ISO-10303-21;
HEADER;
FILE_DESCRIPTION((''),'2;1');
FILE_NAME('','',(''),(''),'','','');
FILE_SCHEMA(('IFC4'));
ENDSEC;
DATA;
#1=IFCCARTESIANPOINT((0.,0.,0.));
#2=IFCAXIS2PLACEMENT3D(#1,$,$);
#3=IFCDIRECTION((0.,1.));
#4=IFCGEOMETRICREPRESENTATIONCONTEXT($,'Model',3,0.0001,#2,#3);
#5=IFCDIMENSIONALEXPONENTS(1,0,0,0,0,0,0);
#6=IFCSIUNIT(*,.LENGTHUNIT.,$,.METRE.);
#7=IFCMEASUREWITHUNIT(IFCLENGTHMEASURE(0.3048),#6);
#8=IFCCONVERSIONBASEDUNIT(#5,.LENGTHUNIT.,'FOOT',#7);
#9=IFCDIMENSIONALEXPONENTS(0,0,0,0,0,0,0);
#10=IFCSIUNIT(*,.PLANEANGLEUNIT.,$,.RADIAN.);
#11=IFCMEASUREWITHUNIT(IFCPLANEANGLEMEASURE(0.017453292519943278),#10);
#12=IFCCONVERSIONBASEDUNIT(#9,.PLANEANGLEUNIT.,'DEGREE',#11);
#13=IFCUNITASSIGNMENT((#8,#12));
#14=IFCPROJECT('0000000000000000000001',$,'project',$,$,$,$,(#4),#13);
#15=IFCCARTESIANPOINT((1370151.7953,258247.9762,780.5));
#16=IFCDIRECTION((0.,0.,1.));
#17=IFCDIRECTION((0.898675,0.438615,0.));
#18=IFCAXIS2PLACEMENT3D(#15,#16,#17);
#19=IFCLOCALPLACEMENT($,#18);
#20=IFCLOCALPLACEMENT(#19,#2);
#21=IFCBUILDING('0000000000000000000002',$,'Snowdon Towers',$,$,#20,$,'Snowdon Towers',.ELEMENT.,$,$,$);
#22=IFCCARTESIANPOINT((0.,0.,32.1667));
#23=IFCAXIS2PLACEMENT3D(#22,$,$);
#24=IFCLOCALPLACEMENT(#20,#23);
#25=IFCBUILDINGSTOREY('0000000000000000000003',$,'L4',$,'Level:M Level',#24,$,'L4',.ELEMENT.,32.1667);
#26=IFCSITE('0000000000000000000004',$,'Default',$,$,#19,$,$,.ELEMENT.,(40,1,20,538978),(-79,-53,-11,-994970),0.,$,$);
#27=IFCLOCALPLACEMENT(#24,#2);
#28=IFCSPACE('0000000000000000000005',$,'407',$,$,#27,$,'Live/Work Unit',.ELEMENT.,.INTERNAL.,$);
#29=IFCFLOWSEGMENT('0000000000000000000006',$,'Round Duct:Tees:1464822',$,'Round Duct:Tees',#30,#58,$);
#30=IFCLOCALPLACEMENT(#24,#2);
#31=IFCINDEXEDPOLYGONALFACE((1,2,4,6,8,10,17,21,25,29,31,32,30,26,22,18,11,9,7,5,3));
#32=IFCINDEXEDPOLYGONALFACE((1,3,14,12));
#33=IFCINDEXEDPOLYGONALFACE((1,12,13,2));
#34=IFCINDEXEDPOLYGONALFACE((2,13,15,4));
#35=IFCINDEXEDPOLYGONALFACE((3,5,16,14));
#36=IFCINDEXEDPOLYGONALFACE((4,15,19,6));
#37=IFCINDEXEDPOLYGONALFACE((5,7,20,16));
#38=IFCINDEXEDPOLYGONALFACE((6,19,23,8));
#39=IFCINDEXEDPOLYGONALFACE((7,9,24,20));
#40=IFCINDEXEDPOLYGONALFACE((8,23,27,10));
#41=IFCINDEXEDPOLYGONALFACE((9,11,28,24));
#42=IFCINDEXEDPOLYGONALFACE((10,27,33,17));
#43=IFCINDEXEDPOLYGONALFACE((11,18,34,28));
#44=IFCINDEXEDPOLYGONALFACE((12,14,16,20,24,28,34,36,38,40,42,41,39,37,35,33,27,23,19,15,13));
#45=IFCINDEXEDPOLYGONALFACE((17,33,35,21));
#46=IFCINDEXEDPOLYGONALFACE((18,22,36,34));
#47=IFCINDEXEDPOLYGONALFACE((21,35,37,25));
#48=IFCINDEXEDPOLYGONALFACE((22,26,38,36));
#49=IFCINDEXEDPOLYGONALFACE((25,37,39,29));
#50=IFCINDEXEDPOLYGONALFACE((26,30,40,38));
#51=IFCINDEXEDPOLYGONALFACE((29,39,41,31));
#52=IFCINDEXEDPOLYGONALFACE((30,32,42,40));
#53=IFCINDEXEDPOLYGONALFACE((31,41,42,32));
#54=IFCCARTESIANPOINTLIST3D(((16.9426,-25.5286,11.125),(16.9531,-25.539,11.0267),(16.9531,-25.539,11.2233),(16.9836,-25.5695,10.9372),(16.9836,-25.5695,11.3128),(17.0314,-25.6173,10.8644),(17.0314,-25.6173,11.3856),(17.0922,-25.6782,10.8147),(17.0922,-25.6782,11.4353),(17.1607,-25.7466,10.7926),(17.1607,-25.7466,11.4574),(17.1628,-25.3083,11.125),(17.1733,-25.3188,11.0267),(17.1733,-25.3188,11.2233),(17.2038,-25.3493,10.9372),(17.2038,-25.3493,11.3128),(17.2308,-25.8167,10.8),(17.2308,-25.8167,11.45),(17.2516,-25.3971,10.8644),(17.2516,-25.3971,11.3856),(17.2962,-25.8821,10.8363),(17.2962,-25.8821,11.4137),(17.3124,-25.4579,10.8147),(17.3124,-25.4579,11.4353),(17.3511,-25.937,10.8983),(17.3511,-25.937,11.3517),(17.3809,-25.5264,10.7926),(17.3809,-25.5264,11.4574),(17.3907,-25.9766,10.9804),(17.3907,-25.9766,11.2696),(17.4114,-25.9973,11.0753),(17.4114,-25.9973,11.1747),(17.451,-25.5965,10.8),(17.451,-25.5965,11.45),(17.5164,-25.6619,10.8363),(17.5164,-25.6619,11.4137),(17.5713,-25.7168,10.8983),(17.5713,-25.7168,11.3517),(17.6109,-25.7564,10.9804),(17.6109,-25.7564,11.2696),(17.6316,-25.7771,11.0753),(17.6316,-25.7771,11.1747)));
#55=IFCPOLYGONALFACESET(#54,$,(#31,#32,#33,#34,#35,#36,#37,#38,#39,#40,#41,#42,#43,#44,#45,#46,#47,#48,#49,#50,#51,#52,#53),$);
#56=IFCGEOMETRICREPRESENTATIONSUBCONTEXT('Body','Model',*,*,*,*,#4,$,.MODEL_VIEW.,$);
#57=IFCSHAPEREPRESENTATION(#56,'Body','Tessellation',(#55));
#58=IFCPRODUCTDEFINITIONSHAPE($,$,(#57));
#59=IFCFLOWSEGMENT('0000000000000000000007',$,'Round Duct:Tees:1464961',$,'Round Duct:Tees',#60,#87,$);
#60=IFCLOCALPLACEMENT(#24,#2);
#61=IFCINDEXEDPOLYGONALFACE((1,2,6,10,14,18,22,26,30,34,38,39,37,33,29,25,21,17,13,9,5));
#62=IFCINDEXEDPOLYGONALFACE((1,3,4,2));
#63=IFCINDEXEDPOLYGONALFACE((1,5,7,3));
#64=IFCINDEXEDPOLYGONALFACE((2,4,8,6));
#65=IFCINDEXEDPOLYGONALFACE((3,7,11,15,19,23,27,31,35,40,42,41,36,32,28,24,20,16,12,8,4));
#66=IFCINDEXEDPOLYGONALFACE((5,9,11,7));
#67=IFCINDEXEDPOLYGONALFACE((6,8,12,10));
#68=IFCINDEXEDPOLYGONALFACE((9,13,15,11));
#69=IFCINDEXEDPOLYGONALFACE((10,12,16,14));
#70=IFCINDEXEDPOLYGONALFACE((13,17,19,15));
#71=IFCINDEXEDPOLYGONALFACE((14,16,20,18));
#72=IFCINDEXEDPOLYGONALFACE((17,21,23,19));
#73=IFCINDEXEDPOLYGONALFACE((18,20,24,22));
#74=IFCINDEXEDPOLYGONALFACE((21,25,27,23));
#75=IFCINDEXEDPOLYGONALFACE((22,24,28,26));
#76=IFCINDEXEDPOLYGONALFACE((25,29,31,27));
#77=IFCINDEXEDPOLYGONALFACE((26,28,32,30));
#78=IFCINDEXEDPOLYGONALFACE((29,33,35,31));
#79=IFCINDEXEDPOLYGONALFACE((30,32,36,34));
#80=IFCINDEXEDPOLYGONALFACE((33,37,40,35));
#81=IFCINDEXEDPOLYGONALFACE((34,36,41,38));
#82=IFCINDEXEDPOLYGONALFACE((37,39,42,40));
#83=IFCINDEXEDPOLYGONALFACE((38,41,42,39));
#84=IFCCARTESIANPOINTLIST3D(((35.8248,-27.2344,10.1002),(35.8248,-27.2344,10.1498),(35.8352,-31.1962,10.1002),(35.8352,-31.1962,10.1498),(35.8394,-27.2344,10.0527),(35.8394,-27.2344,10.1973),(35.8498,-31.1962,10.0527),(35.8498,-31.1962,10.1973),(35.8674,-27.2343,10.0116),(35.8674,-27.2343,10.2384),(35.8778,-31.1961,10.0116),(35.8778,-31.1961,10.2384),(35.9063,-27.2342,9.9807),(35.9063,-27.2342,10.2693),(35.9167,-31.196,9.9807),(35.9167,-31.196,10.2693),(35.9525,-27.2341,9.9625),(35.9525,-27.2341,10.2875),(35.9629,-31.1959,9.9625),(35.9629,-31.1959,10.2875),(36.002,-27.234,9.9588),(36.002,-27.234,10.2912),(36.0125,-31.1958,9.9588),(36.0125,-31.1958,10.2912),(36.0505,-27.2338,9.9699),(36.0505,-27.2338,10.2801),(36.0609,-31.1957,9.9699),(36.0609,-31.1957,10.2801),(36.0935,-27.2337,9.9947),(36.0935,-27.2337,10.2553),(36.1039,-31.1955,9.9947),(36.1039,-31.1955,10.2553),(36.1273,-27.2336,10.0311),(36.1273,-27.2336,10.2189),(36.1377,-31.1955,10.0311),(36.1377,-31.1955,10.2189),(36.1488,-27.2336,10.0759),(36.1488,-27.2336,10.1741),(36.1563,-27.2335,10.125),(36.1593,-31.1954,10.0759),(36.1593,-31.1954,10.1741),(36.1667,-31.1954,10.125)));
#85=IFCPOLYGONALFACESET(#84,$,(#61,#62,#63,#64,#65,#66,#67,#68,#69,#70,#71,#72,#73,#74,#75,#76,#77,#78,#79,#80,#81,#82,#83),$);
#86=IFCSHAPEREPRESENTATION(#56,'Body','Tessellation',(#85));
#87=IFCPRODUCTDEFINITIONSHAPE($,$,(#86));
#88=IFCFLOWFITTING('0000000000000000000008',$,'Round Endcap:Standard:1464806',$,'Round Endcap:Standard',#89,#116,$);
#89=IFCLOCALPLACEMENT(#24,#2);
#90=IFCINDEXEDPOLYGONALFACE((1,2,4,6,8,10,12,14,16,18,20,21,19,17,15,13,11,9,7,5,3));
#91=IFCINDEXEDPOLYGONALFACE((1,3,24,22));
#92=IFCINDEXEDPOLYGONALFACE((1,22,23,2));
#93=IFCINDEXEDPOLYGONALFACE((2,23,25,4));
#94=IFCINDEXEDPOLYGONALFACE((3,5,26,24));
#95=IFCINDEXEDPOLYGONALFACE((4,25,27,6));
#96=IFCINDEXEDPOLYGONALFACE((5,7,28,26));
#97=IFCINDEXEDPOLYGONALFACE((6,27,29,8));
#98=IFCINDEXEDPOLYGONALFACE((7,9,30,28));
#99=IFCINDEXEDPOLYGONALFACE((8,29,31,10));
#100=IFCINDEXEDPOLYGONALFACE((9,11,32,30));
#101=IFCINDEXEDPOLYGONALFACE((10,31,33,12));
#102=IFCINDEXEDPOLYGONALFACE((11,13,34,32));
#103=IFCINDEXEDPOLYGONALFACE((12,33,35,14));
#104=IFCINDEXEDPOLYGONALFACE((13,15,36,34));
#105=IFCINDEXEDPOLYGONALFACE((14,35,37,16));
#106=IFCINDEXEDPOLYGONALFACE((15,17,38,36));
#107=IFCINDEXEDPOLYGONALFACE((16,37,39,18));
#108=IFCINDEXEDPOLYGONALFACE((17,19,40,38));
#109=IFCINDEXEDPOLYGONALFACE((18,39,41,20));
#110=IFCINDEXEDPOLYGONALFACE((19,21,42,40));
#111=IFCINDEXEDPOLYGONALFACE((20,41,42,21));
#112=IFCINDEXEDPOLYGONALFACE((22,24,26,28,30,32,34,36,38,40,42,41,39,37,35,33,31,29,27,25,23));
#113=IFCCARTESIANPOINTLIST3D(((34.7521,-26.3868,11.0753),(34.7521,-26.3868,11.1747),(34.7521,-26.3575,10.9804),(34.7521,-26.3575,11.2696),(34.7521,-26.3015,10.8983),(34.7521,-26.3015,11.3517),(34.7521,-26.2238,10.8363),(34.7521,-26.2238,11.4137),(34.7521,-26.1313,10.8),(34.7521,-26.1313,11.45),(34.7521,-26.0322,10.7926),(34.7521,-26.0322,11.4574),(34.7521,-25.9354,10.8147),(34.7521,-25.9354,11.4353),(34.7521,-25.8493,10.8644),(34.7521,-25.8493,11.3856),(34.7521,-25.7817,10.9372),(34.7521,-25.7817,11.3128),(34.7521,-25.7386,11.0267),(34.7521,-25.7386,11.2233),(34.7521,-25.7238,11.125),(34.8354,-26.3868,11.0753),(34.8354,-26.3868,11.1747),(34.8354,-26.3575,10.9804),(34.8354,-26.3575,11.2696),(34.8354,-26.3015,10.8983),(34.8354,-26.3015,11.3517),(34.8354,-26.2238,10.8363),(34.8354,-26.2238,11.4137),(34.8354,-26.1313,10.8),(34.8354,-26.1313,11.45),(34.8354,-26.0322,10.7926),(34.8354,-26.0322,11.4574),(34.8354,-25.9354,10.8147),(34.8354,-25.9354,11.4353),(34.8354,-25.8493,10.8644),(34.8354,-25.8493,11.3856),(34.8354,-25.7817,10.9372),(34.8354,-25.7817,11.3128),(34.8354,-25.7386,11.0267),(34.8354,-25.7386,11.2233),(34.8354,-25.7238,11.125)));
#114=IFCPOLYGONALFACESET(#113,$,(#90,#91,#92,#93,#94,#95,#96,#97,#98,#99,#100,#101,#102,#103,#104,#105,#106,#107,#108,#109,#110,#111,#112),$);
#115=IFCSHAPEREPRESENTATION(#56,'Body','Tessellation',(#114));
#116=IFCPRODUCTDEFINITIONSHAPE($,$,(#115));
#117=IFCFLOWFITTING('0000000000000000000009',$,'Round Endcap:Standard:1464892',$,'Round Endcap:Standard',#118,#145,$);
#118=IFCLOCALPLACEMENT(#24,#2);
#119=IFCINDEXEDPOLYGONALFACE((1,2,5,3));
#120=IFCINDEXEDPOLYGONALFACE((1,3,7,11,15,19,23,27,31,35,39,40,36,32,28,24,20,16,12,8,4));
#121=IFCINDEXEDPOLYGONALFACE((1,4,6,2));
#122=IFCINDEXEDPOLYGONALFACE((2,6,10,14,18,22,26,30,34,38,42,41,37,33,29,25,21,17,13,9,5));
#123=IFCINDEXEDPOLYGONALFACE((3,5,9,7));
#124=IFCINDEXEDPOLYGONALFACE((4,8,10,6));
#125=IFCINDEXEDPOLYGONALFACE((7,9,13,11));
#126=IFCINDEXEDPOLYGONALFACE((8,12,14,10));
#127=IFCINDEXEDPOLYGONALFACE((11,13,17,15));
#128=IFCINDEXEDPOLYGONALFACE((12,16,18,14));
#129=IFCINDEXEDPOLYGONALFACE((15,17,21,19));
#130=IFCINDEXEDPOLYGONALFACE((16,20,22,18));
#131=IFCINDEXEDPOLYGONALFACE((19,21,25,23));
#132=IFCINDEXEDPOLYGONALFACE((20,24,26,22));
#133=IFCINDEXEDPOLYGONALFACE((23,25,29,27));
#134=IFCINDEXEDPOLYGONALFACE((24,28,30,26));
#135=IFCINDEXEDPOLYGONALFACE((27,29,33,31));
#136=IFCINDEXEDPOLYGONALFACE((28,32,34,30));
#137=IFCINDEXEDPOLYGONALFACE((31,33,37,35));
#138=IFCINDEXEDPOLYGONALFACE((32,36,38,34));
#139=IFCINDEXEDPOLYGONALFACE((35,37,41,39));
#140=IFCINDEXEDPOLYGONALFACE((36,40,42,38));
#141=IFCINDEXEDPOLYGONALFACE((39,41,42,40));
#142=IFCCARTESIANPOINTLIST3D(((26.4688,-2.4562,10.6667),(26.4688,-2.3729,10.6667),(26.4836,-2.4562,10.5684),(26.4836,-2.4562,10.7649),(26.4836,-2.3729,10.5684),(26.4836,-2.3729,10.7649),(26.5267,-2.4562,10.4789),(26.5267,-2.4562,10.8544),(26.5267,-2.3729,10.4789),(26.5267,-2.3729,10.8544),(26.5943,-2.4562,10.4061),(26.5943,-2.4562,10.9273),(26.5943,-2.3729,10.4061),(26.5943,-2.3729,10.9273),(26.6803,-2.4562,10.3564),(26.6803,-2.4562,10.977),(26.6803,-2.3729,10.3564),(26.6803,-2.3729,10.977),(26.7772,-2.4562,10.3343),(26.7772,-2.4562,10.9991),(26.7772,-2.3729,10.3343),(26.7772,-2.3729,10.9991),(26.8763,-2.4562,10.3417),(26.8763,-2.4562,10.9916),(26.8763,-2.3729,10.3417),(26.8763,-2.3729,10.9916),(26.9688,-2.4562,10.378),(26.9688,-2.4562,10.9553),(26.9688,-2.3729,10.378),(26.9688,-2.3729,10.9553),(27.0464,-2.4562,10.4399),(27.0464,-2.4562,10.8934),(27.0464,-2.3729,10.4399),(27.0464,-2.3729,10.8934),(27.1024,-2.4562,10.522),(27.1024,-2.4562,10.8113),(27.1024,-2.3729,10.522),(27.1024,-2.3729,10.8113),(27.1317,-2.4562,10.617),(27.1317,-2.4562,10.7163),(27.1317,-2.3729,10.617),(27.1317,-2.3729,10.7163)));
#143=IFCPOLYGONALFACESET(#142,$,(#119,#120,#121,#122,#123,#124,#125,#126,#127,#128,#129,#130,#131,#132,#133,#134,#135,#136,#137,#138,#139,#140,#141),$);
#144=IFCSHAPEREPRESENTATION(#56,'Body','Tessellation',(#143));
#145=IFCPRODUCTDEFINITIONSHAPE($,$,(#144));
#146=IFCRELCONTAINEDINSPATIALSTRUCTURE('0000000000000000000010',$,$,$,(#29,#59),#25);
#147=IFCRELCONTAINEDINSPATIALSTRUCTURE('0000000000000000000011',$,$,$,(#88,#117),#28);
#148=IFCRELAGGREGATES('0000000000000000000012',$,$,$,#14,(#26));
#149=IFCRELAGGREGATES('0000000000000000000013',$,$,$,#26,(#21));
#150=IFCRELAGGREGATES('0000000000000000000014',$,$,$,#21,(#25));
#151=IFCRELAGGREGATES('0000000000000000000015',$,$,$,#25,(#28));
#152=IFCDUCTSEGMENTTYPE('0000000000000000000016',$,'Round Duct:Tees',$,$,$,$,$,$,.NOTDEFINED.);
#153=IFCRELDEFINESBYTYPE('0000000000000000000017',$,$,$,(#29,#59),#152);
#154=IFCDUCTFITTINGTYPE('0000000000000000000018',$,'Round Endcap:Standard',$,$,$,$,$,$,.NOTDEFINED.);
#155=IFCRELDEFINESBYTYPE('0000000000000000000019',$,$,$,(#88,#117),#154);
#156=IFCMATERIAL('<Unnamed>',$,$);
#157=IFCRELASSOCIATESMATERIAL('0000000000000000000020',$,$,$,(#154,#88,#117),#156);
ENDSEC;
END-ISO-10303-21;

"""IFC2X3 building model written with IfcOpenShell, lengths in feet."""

from ifc_helpers import new_model, entity, si_unit, converted_unit, direction, frame, frame_2d, origin, origin_2d_with_axis, place, context, subcontext, project, spatial, circle, extrude, source, transform, mapped, material, type_object, type_shapes, element, save


model = new_model("IFC2X3")

# Units and contexts
model_context = context("Model", 3, precision=0.0001, world=origin(), true_north=direction((0.0, 1.0)))
body_context = subcontext(model_context, "Body", "Model", "MODEL_VIEW")
ifc_project = project(units=[converted_unit("LENGTHUNIT", "FOOT", entity("IfcLengthMeasure", 0.3048), si_unit("LENGTHUNIT", "METRE"), dimensions=[1, 0, 0, 0, 0, 0, 0]), converted_unit("PLANEANGLEUNIT", "DEGREE", entity("IfcPlaneAngleMeasure", 0.017453292519943278), si_unit("PLANEANGLEUNIT", "RADIAN"), dimensions=[0, 0, 0, 0, 0, 0, 0])], contexts=[model_context])

# Site, building, storey
site_placement = place(None, frame((1370151.7953, 258247.9762, 780.5), z_axis=(0.0, 0.0, 1.0), x_axis=(0.898675, 0.438615, 0.0)))
site = spatial("IfcSite", under=ifc_project, at=site_placement, Name="Default", CompositionType="ELEMENT", RefLatitude=(40, 1, 20, 538978), RefLongitude=(-79, -53, -11, -994970), RefElevation=0.0)
building_placement = place(site_placement, origin())
building = spatial("IfcBuilding", under=site, at=building_placement, Name="Snowdon Towers", LongName="Snowdon Towers", CompositionType="ELEMENT")
storey_placement = place(building_placement, frame((0.0, 0.0, 32.1667)))
storey = spatial("IfcBuildingStorey", under=building, at=storey_placement, Name="L4", ObjectType="Level:M Level", LongName="L4", CompositionType="ELEMENT", Elevation=32.1667)

# Flow segments
duct_segment_type = type_object("IfcDuctSegmentType", Name="Round Duct:Tees", PredefinedType="NOTDEFINED")
flow_segment_1_placement = place(storey_placement, frame((16.9374, -26.0052, 10.7864)))
element("IfcFlowSegment", 1, at=flow_segment_1_placement, inside=storey, type_object=duct_segment_type, Name="Round Duct:Tees:1464822", ObjectType="Round Duct:Tees", context=body_context, shape_type="SweptSolid", body=[
    extrude(circle(Radius=0.3333, at=origin_2d_with_axis()), frame((0.2409, 0.2409, 0.3386), z_axis=(0.707107, 0.707107, 0.0), x_axis=(-0.707107, 0.707107, 0.0)), (0.0, 0.0, 1.0), 0.3114),
])
flow_segment_2_placement = place(storey_placement, frame((35.8177, -31.1963, 9.9531)))
element("IfcFlowSegment", 2, at=flow_segment_2_placement, inside=storey, type_object=duct_segment_type, Name="Round Duct:Tees:1464961", ObjectType="Round Duct:Tees", context=body_context, shape_type="SweptSolid", body=[
    extrude(circle(Radius=0.1667, at=origin_2d_with_axis()), frame((0.1823, 0.0004, 0.1719), z_axis=(-0.002628, 0.999997, 0.0), x_axis=(0.999997, 0.002628, 0.0)), (0.0, 0.0, 1.0), 3.9618),
])

# Shared definitions
space_placement = place(storey_placement, origin())
space = spatial("IfcSpace", under=storey, at=space_placement, Name="407", LongName="Live/Work Unit", CompositionType="ELEMENT", InteriorOrExteriorSpace="INTERNAL")

# Flow fittings
ifc_material = material(Name="<Unnamed>")
duct_fitting_type = type_object("IfcDuctFittingType", Name="Round Endcap:Standard", PredefinedType="NOTDEFINED", material=ifc_material)
shared_shape_1 = source(origin(), body_context, "Body", "SweptSolid", [
    extrude(circle(Radius=0.3333, at=frame_2d((0.0, 0.0), x_axis=(1.0, 0.0))), frame((0.0, 0.0, 0.0), z_axis=(1.0, 0.0, 0.0), x_axis=(0.0, 1.0, 0.0)), (0.0, 0.0, 1.0), 0.0833),
])
type_shapes(duct_fitting_type, [shared_shape_1])
flow_fitting_1_placement = place(space_placement, frame((34.7521, -26.0572, 11.125)))
element("IfcFlowFitting", 3, at=flow_fitting_1_placement, inside=space, type_object=duct_fitting_type, material=ifc_material, Name="Round Endcap:Standard:1464806", ObjectType="Round Endcap:Standard", context=body_context, shape_type="MappedRepresentation", body=[
    mapped(shared_shape_1, transform((0.0, 0.0, 0.0), scale=1.0)),
])
flow_fitting_2_placement = place(space_placement, frame((26.8021, -2.4562, 10.6667), z_axis=(0.0, 0.0, 1.0), x_axis=(0.0, 1.0, 0.0)))
element("IfcFlowFitting", 4, at=flow_fitting_2_placement, inside=space, type_object=duct_fitting_type, material=ifc_material, Name="Round Endcap:Standard:1464892", ObjectType="Round Endcap:Standard", context=body_context, shape_type="MappedRepresentation", body=[
    mapped(shared_shape_1, transform((0.0, 0.0, 0.0), scale=1.0)),
])

save(model, "model.ifc")
